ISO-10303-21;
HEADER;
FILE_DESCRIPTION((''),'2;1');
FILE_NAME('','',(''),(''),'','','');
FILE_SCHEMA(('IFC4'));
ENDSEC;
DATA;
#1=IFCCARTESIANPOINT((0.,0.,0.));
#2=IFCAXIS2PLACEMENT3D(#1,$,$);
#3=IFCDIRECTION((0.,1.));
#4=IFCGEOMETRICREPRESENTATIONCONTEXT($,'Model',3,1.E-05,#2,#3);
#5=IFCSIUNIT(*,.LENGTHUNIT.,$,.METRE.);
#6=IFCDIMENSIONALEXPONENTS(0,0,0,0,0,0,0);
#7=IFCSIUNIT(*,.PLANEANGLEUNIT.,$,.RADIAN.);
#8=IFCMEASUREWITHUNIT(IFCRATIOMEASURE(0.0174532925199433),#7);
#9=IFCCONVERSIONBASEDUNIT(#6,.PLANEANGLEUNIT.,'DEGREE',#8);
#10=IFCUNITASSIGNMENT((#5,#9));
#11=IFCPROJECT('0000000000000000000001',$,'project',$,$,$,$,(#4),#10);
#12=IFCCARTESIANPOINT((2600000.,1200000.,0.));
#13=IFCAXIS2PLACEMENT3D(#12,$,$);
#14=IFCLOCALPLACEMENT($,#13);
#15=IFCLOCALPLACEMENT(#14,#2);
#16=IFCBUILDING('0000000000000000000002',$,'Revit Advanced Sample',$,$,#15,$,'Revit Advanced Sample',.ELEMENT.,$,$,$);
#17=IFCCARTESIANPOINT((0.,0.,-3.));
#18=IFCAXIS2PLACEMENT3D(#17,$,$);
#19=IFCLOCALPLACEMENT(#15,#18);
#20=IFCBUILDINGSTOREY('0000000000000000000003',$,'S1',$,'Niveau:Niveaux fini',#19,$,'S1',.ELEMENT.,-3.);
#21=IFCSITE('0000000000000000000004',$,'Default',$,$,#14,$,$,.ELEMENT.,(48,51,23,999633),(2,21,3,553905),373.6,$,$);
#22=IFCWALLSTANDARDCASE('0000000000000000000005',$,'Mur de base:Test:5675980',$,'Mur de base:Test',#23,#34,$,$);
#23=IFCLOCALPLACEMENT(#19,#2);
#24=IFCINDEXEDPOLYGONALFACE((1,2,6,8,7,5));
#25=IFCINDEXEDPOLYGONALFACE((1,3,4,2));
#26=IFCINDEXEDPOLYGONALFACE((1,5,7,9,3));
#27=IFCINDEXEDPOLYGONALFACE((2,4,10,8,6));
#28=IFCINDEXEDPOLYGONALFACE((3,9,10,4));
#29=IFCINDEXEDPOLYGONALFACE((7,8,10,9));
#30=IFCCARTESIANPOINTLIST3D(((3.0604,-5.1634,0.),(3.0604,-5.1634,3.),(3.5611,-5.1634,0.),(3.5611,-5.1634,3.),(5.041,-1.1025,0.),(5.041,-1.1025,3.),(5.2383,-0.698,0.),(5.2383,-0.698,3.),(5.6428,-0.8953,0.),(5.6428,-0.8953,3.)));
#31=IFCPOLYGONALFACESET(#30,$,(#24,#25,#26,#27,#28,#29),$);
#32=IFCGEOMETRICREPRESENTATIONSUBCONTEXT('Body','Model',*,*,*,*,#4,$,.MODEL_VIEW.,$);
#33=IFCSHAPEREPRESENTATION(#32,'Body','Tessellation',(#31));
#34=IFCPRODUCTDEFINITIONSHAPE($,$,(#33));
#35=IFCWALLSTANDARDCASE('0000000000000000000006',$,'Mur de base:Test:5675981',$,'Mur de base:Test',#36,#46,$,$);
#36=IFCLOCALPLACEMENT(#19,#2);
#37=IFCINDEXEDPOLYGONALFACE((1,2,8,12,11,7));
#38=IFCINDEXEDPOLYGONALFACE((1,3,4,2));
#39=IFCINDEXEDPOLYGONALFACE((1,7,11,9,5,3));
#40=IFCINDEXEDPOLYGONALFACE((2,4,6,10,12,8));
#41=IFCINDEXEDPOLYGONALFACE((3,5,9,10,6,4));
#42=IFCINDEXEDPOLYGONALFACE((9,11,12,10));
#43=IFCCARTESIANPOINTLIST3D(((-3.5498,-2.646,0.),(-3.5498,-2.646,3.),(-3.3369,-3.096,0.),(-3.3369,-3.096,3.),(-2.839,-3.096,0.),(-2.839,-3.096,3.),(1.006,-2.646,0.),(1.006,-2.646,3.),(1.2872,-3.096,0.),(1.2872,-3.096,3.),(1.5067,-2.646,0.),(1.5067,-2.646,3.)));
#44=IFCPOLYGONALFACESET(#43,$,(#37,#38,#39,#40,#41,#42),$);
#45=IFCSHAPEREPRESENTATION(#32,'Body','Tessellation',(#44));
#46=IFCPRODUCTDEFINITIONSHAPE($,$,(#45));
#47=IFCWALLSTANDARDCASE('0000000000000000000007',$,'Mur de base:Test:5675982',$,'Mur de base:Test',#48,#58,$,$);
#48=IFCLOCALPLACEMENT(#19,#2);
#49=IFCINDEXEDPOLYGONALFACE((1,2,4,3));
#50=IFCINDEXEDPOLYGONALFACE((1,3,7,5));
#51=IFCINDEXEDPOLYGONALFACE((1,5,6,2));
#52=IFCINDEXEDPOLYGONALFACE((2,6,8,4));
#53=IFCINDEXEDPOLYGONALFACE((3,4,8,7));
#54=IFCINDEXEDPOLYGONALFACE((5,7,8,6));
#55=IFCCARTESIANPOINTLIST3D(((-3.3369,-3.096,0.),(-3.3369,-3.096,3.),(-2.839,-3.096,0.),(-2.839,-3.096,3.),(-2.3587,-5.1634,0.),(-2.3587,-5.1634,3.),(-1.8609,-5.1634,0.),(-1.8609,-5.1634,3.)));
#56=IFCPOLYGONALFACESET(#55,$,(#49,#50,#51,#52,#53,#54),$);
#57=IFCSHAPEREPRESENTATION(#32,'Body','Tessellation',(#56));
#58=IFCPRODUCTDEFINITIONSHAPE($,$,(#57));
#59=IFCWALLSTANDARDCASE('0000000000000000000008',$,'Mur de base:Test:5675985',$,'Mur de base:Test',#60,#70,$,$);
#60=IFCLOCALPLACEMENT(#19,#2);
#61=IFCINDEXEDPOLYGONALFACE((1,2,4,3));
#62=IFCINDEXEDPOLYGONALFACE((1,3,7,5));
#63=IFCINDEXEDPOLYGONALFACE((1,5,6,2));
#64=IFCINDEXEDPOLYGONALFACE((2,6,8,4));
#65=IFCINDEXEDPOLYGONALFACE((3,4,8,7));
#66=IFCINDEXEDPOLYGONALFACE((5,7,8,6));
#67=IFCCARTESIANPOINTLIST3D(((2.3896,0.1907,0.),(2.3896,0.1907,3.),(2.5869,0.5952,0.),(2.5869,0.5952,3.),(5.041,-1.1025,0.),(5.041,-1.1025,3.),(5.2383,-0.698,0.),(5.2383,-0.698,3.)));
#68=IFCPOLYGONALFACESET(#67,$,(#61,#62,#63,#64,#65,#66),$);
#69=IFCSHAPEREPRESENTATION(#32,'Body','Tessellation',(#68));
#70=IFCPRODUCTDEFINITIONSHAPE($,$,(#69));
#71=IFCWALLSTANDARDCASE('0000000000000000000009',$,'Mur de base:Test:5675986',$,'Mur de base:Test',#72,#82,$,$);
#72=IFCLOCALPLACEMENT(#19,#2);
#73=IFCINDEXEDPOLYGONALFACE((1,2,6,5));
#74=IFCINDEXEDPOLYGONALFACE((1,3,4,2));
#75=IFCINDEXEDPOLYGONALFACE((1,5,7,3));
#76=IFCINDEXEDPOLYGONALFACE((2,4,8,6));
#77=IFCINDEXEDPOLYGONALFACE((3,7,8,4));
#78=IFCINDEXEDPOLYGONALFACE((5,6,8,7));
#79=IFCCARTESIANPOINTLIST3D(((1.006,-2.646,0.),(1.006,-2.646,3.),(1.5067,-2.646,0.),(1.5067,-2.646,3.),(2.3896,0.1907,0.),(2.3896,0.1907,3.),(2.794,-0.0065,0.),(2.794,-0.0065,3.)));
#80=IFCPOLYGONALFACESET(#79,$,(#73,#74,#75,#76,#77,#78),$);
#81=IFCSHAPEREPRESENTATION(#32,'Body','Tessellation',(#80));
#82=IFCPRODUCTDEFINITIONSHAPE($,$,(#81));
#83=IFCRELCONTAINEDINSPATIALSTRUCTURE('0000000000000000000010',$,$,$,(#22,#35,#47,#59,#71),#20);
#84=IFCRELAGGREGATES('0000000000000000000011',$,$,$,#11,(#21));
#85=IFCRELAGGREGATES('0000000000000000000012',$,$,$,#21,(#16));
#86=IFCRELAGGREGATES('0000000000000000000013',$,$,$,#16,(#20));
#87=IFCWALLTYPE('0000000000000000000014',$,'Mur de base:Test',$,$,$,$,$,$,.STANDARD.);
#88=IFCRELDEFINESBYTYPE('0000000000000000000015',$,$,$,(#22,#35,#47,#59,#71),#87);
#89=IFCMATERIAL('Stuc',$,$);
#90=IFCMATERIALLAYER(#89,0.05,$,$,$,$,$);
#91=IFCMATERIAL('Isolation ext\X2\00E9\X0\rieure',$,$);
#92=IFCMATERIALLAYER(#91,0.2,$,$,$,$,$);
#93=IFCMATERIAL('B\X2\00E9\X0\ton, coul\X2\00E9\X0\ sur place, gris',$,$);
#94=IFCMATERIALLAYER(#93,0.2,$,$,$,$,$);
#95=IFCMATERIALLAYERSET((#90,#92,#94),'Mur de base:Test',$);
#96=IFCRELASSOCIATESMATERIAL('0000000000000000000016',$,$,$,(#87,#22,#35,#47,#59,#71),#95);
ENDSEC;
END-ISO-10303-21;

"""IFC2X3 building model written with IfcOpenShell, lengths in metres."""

from ifc_helpers import new_model, entity, si_unit, converted_unit, direction, frame, frame_2d, origin, place, context, subcontext, project, spatial, polyline, rectangle, outline, extrude, material, layer, layer_set, layer_usage, type_object, element, save


model = new_model("IFC2X3")

# Units and contexts
model_context = context("Model", 3, precision=1e-05, world=origin(), true_north=direction((0.0, 1.0)))
body_context = subcontext(model_context, "Body", "Model", "MODEL_VIEW")
ifc_project = project(units=[si_unit("LENGTHUNIT", "METRE"), converted_unit("PLANEANGLEUNIT", "DEGREE", entity("IfcRatioMeasure", 0.0174532925199433), si_unit("PLANEANGLEUNIT", "RADIAN"), dimensions=[0, 0, 0, 0, 0, 0, 0])], contexts=[model_context])

# Site, building, storey
site_placement = place(None, frame((2600000.0, 1200000.0, 0.0)))
site = spatial("IfcSite", under=ifc_project, at=site_placement, Name="Default", CompositionType="ELEMENT", RefLatitude=(48, 51, 23, 999633), RefLongitude=(2, 21, 3, 553905), RefElevation=373.6)
building_placement = place(site_placement, origin())
building = spatial("IfcBuilding", under=site, at=building_placement, Name="Revit Advanced Sample", LongName="Revit Advanced Sample", CompositionType="ELEMENT")
storey_placement = place(building_placement, frame((0.0, 0.0, -3.0)))
storey = spatial("IfcBuildingStorey", under=building, at=storey_placement, Name="S1", ObjectType="Niveau:Niveaux fini", LongName="S1", CompositionType="ELEMENT", Elevation=-3.0)

# Shared definitions
ifc_material_1 = material(Name="Stuc")
ifc_layer_1 = layer(ifc_material_1, 0.05)
ifc_material_2 = material(Name="Isolation extérieure")
ifc_layer_2 = layer(ifc_material_2, 0.2)
ifc_material_3 = material(Name="Béton, coulé sur place, gris")
ifc_layer_3 = layer(ifc_material_3, 0.2)
ifc_layer_set_1 = layer_set([ifc_layer_1, ifc_layer_2, ifc_layer_3], Name="Mur de base:Test")
wall_type = type_object("IfcWallType", Name="Mur de base:Test", PredefinedType="STANDARD", material=ifc_layer_set_1)

# Walls
ifc_layer_usage_1 = layer_usage(ifc_layer_set_1, "AXIS2", "POSITIVE", -0.225)
wall_1_placement = place(storey_placement, frame((3.2626, -5.262, 0.0), z_axis=(0.0, 0.0, 1.0), x_axis=(0.438371, 0.898794, 0.0)))
element("IfcWallStandardCase", 1, at=wall_1_placement, inside=storey, type_object=wall_type, material=ifc_layer_usage_1, Name="Mur de base:Test:5675980", ObjectType="Mur de base:Test", context=body_context, shape_type="SweptSolid", body=[
    extrude(outline(polyline([(4.9682, -0.225), (4.9682, 0.225), (4.5182, 0.225), (0.0, 0.225), (0.2195, -0.225), (4.9682, -0.225)])), origin(), (0.0, 0.0, 1.0), 3.0),
])
ifc_layer_usage_2 = layer_usage(ifc_layer_set_1, "AXIS2", "POSITIVE", -0.225)
wall_2_placement = place(storey_placement, frame((1.5067, -2.871, 0.0), z_axis=(0.0, 0.0, 1.0), x_axis=(-1.0, 0.0, 0.0)))
element("IfcWallStandardCase", 2, at=wall_2_placement, inside=storey, type_object=wall_type, material=ifc_layer_usage_2, Name="Mur de base:Test:5675981", ObjectType="Mur de base:Test", context=body_context, shape_type="SweptSolid", body=[
    extrude(outline(polyline([(5.0565, -0.225), (4.8435, 0.225), (4.3457, 0.225), (0.2195, 0.225), (0.0, -0.225), (0.5007, -0.225), (5.0565, -0.225)])), origin(), (0.0, 0.0, 1.0), 3.0),
])
ifc_layer_usage_3 = layer_usage(ifc_layer_set_1, "AXIS2", "POSITIVE", -0.225)
wall_3_placement = place(storey_placement, frame((-3.1335, -2.9998, 0.0), z_axis=(0.0, 0.0, 1.0), x_axis=(0.427693, -0.903924, 0.0)))
element("IfcWallStandardCase", 3, at=wall_3_placement, inside=storey, type_object=wall_type, material=ifc_layer_usage_3, Name="Mur de base:Test:5675982", ObjectType="Mur de base:Test", context=body_context, shape_type="SweptSolid", body=[
    extrude(outline(polyline([(2.2871, -0.225), (2.5, 0.225), (0.2129, 0.225), (0.0, -0.225), (2.2871, -0.225)])), origin(), (0.0, 0.0, 1.0), 3.0),
])
ifc_layer_usage_4 = layer_usage(ifc_layer_set_1, "AXIS2", "POSITIVE", -0.225)
wall_4_placement = place(storey_placement, frame((5.1397, -0.9002, 0.0), z_axis=(0.0, 0.0, 1.0), x_axis=(-0.898794, 0.438371, 0.0)))
element("IfcWallStandardCase", 4, at=wall_4_placement, inside=storey, type_object=wall_type, material=ifc_layer_usage_4, Name="Mur de base:Test:5675985", ObjectType="Mur de base:Test", context=body_context, shape_type="SweptSolid", body=[
    extrude(rectangle(XDim=2.95, YDim=0.45, at=frame_2d((1.475, 0.0), x_axis=(-1.0, 0.0))), origin(), (0.0, 0.0, 1.0), 3.0),
])
ifc_layer_usage_5 = layer_usage(ifc_layer_set_1, "AXIS2", "POSITIVE", -0.225)
wall_5_placement = place(storey_placement, frame((2.5918, 0.0921, 0.0), z_axis=(0.0, 0.0, 1.0), x_axis=(-0.438371, -0.898794, 0.0)))
element("IfcWallStandardCase", 5, at=wall_5_placement, inside=storey, type_object=wall_type, material=ifc_layer_usage_5, Name="Mur de base:Test:5675986", ObjectType="Mur de base:Test", context=body_context, shape_type="SweptSolid", body=[
    extrude(outline(polyline([(3.1562, -0.225), (2.9367, 0.225), (0.0, 0.225), (0.0, -0.225), (3.1562, -0.225)])), origin(), (0.0, 0.0, 1.0), 3.0),
])

save(model, "model.ifc")
